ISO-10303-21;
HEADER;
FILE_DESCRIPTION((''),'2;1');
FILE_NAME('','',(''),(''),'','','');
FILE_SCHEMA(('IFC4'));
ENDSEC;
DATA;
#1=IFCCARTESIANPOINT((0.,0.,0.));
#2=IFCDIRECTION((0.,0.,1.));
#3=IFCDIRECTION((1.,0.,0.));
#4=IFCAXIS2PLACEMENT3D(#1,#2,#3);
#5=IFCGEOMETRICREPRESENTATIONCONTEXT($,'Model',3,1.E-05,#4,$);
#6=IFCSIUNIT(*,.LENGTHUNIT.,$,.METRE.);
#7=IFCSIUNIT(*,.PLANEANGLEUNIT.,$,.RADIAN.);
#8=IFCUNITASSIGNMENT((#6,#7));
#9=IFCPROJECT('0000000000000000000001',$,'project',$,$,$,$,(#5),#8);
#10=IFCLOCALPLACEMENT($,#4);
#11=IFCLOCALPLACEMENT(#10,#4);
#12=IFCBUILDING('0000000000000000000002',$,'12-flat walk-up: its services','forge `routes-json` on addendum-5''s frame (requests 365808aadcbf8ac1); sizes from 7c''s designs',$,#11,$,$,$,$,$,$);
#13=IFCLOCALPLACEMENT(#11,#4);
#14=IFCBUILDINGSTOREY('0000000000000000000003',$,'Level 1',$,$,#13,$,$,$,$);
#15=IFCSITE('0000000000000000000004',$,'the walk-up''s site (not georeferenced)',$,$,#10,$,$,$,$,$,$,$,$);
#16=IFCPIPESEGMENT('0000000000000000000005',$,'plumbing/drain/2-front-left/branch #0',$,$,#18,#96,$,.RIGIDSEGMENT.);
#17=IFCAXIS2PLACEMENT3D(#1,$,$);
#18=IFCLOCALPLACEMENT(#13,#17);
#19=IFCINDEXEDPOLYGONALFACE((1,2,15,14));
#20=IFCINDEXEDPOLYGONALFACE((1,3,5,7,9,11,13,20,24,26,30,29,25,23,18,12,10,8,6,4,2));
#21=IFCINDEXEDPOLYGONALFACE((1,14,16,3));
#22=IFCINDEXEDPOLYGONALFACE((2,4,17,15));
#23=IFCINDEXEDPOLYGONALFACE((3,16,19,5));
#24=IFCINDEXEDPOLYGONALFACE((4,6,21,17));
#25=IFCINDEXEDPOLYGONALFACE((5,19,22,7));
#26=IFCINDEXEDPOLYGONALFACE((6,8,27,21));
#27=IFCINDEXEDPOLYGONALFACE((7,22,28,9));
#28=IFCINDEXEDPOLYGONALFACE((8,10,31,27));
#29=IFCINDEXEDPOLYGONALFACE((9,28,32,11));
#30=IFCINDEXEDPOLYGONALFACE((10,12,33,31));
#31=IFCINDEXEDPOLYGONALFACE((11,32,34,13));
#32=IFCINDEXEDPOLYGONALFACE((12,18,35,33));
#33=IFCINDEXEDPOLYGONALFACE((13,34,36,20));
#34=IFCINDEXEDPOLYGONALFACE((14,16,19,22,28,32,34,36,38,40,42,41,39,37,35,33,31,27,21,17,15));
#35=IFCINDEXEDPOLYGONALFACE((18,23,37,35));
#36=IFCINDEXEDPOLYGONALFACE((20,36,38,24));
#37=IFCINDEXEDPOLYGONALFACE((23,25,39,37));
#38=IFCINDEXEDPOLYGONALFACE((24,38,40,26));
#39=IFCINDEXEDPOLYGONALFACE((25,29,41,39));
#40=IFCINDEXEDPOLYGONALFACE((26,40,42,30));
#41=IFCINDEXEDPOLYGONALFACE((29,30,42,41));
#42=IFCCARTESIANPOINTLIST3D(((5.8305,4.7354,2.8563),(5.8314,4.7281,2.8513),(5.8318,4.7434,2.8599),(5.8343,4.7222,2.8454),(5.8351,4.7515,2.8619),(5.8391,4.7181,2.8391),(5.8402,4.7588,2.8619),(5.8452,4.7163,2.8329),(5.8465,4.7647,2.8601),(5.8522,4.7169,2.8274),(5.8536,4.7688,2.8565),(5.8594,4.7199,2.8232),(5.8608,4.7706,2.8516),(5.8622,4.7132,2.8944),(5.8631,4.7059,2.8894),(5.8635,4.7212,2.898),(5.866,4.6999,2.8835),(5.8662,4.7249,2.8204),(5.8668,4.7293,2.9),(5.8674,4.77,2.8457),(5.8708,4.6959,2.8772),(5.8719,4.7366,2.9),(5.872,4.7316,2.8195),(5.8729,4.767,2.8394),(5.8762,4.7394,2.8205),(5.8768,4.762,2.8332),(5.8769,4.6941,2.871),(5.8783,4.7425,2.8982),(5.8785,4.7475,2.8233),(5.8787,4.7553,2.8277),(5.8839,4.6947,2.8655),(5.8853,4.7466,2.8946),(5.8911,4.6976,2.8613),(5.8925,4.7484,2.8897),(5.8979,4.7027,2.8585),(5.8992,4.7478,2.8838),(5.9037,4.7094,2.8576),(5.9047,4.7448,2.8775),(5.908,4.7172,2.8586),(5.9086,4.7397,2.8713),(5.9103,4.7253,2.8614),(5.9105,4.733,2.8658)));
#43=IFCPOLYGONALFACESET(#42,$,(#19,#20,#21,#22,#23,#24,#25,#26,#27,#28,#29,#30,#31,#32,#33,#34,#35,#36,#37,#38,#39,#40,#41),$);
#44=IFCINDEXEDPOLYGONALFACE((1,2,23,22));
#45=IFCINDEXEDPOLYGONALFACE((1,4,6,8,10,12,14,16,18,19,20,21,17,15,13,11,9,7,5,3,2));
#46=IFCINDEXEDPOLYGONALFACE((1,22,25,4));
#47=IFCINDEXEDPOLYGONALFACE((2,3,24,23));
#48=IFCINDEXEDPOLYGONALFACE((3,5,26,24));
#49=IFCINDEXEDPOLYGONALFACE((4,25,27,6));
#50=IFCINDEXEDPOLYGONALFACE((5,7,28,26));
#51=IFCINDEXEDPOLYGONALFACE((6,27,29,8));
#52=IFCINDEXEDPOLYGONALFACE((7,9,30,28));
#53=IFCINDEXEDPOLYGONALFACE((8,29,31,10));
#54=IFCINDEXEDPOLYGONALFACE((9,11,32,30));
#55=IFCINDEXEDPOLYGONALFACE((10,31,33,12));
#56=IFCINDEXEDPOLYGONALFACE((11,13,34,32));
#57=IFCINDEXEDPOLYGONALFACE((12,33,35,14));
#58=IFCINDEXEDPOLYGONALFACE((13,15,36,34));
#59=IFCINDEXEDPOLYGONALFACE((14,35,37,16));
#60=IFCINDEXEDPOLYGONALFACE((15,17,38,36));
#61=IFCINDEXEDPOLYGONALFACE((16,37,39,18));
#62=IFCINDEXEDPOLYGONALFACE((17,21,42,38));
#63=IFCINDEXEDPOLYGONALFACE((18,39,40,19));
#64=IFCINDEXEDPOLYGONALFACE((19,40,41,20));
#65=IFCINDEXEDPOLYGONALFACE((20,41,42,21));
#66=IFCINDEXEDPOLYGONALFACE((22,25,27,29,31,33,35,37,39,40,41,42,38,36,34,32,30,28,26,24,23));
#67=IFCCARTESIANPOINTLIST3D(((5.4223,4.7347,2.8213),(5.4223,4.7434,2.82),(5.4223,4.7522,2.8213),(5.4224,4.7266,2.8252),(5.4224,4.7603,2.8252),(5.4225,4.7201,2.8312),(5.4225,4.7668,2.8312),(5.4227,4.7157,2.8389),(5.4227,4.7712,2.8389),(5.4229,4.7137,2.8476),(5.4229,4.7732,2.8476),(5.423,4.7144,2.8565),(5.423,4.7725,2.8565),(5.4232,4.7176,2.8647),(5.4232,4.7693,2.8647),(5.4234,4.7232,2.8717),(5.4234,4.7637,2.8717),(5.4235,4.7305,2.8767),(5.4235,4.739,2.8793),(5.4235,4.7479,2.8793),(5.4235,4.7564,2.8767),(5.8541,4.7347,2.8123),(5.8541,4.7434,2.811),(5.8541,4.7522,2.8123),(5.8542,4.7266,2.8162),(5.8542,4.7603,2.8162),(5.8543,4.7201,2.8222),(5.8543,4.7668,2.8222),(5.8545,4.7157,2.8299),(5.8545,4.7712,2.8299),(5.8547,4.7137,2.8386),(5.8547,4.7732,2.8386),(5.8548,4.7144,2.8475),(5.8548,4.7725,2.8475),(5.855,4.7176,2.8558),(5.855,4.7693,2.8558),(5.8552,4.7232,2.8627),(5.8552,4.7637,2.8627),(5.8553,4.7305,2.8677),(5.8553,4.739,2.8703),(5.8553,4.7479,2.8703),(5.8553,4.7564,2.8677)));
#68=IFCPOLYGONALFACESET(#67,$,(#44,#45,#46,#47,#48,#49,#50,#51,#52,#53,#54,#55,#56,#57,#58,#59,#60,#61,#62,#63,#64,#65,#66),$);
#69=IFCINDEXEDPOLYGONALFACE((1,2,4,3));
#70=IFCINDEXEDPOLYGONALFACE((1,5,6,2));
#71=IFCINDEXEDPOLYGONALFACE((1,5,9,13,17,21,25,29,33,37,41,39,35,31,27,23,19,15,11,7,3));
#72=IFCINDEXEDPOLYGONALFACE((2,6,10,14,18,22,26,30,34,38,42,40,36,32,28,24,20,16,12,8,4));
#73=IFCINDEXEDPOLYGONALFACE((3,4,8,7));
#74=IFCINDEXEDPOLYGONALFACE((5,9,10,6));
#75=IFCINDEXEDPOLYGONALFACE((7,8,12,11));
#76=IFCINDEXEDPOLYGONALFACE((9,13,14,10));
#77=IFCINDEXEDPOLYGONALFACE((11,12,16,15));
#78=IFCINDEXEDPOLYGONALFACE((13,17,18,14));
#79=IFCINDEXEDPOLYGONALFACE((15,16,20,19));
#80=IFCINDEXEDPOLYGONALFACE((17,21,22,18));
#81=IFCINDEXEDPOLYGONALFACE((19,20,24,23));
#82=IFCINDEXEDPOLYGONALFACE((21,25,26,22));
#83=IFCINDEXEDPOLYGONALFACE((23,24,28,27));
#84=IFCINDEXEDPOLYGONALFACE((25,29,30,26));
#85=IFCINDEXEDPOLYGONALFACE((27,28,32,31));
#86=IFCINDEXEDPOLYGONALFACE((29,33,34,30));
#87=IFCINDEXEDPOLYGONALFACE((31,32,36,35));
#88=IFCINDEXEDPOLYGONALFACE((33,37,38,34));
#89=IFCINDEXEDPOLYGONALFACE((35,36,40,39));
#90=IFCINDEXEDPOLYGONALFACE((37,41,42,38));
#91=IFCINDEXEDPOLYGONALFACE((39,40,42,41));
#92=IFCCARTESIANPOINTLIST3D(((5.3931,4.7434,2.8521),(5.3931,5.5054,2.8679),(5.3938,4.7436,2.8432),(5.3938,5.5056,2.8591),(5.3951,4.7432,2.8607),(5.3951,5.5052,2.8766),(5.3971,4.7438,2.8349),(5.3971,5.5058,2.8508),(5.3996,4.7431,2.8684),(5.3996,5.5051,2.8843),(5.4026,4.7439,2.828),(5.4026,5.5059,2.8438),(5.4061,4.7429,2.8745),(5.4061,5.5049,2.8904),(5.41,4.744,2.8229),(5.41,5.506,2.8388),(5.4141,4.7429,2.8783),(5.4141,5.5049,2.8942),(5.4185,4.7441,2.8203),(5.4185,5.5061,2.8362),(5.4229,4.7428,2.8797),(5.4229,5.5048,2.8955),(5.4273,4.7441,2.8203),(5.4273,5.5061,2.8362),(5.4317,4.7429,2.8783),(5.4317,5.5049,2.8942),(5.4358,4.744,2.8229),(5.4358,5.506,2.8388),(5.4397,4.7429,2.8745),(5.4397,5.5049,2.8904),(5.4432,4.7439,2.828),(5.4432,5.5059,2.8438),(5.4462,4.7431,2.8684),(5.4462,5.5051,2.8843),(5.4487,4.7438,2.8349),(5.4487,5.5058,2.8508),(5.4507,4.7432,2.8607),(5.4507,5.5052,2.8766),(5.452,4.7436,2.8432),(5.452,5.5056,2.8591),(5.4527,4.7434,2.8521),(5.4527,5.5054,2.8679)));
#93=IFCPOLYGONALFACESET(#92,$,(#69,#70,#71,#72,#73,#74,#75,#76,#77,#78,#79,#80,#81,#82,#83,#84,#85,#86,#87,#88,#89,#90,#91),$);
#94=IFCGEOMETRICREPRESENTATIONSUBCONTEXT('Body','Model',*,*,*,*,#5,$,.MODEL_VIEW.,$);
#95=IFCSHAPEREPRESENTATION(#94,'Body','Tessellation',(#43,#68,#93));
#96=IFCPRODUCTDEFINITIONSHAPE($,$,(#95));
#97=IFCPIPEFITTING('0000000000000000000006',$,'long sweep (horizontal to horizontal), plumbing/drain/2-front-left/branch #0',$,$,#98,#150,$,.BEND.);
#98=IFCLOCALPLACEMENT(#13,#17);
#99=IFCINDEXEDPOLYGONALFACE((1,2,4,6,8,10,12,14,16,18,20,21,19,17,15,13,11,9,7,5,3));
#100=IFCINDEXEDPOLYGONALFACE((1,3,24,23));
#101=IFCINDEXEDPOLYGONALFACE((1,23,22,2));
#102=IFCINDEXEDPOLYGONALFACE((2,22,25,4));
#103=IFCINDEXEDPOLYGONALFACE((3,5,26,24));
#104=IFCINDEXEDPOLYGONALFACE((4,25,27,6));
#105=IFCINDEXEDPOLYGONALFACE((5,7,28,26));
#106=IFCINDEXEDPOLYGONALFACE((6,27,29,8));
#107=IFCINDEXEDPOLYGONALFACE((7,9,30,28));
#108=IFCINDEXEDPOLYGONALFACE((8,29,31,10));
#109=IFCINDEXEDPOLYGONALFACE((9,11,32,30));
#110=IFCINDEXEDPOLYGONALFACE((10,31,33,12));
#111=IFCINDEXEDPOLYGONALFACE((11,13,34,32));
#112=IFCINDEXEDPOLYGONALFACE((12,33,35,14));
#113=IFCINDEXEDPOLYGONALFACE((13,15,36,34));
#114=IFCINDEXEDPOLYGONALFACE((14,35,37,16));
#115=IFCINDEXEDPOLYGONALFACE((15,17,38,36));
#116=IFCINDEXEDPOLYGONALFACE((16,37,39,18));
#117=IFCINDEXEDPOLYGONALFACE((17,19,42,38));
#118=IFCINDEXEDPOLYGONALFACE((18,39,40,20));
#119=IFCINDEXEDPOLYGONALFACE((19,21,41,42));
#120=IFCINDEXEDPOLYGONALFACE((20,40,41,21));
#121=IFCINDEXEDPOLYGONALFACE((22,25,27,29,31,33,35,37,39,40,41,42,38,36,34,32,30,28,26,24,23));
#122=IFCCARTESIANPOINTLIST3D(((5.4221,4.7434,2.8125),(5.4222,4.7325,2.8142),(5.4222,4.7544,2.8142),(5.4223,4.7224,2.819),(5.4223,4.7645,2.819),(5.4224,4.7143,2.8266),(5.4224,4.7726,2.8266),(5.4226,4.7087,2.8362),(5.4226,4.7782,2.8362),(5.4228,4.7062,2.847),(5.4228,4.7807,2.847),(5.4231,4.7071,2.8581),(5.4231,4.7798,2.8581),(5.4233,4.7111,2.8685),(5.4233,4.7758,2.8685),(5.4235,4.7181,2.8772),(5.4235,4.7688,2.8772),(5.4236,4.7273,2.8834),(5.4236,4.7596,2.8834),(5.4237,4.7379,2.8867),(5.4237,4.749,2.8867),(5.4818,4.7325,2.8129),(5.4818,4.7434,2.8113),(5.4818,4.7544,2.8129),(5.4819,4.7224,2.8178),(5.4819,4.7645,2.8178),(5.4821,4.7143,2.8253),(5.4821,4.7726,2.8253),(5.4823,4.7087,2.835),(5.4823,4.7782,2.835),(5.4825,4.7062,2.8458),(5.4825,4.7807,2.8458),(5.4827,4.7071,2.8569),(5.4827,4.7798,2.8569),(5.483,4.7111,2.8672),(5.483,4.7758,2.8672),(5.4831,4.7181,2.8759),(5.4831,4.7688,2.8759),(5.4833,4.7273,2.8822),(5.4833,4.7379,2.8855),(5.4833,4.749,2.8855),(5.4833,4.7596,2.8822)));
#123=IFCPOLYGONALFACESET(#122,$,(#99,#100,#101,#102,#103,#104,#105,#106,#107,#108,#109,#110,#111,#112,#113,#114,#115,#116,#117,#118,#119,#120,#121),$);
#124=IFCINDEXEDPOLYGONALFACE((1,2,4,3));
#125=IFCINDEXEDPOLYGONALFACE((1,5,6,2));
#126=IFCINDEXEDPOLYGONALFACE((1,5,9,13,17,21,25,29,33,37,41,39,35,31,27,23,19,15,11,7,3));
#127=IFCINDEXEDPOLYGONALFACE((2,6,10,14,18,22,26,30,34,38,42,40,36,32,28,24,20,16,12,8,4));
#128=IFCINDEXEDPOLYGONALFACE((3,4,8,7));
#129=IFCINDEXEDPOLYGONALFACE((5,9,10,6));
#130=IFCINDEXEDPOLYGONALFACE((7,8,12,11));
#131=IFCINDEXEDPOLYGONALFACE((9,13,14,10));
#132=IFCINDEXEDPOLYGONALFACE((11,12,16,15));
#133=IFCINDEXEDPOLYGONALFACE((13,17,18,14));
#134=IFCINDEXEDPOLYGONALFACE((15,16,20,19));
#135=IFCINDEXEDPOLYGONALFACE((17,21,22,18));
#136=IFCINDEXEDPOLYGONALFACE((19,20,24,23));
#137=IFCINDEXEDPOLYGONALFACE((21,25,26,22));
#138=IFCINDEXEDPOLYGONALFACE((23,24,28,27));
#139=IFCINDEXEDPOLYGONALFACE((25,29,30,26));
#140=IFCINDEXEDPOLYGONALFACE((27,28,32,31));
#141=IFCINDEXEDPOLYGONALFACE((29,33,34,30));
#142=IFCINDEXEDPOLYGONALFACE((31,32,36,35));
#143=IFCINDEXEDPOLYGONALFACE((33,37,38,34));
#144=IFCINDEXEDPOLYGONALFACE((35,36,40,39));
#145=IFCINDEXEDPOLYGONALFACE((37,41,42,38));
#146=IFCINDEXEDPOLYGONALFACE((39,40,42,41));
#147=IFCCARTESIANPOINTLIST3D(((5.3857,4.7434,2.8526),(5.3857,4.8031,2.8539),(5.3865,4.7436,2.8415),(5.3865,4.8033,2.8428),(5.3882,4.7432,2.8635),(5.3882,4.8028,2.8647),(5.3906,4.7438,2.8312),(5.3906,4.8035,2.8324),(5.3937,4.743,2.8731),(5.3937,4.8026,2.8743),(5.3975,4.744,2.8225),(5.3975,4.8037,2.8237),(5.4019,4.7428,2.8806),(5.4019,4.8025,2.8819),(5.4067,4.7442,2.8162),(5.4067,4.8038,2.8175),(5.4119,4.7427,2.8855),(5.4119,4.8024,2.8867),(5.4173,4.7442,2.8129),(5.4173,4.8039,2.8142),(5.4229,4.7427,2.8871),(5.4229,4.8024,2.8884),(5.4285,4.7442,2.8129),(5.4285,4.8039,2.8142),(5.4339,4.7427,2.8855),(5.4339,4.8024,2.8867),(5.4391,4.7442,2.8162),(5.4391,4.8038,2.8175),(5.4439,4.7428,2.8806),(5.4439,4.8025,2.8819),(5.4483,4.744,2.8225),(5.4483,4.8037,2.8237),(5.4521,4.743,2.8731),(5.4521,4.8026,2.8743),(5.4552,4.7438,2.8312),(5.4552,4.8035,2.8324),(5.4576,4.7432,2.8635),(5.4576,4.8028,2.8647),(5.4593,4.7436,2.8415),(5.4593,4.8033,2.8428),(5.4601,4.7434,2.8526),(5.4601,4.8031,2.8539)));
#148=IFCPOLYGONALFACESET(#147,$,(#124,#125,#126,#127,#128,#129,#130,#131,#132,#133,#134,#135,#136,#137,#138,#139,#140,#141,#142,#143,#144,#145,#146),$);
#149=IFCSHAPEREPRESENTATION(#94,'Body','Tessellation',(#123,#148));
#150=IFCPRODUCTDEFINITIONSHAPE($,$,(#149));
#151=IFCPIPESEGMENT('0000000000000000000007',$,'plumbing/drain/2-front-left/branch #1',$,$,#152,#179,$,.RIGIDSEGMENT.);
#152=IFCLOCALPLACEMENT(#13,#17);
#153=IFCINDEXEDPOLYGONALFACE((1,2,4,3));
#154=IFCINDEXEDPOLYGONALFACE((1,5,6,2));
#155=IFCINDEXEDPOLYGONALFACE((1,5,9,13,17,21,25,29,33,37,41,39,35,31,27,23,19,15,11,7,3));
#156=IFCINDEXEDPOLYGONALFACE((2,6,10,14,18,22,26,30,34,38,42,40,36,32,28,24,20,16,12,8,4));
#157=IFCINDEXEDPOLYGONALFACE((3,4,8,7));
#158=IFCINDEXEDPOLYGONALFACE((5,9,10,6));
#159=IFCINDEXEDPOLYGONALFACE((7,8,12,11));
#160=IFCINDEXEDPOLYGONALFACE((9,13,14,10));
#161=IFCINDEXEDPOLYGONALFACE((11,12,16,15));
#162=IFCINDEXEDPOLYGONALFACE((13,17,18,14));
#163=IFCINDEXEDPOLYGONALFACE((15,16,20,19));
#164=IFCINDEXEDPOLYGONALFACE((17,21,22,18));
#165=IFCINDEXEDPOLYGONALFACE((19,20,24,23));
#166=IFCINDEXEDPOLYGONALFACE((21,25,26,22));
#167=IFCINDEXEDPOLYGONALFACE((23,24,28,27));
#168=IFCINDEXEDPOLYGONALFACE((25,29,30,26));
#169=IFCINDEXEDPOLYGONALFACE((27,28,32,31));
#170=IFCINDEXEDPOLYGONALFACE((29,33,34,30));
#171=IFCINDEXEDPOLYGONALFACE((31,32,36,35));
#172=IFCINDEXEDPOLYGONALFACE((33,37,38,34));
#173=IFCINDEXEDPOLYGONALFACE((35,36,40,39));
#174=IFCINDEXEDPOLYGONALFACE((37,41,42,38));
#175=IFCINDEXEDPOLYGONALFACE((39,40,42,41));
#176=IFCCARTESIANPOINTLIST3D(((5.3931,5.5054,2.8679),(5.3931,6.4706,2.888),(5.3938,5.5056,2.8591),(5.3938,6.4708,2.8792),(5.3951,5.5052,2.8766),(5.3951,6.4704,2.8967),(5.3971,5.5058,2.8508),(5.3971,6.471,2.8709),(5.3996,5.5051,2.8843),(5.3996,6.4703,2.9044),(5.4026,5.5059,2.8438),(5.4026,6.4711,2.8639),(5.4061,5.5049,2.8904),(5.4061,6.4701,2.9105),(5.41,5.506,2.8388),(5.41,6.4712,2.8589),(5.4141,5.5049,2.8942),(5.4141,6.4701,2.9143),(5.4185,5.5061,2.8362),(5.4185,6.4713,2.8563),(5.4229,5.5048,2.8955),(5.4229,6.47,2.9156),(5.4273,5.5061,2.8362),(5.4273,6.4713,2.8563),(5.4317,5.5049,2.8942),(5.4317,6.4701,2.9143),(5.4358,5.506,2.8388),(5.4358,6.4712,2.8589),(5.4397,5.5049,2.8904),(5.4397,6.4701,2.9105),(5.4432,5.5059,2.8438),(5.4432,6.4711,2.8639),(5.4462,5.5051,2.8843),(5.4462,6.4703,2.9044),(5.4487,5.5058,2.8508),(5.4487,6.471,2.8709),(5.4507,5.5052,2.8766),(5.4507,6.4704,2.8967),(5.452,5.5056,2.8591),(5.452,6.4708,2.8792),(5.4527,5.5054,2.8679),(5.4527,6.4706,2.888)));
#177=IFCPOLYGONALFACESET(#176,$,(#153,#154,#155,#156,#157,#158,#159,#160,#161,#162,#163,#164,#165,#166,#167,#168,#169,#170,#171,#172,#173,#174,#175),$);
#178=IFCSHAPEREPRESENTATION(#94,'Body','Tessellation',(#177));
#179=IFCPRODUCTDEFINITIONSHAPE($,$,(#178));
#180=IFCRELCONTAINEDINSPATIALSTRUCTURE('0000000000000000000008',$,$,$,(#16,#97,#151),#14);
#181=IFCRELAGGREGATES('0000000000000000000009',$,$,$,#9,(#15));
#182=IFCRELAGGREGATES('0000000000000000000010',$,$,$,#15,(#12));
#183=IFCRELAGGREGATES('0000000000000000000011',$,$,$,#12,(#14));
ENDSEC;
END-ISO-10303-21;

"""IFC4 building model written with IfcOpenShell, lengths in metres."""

from ifc_helpers import new_model, entity, si_unit, frame, origin_with_axes, place, context, subcontext, project, spatial, element, save


model = new_model("IFC4")

# Units and contexts
model_context = context("Model", 3, precision=1e-05, world=origin_with_axes())
body_context = subcontext(model_context, "Body", "Model", "MODEL_VIEW")
ifc_project = project(units=[si_unit("LENGTHUNIT", "METRE"), si_unit("PLANEANGLEUNIT", "RADIAN")], contexts=[model_context])

# Site, building, storey
site_placement = place(None, origin_with_axes())
site = spatial("IfcSite", under=ifc_project, at=site_placement, Name="the walk-up's site (not georeferenced)")
building_placement = place(site_placement, origin_with_axes())
building = spatial("IfcBuilding", under=site, at=building_placement, Name="12-flat walk-up: its services", Description="forge `routes-json` on addendum-5's frame (requests 365808aadcbf8ac1); sizes from 7c's designs")
storey_placement = place(building_placement, origin_with_axes())
storey = spatial("IfcBuildingStorey", under=building, at=storey_placement, Name="Level 1")

# Pipe segment
pipe_segment_1_placement = place(storey_placement, frame((5.8864, 4.7212, 2.8789), z_axis=(0.0, 0.0, 1.0), x_axis=(1.0, 0.0, 0.0)))
element("IfcPipeSegment", 1, at=pipe_segment_1_placement, inside=storey, Name="plumbing/drain/2-front-left/branch #0", PredefinedType="RIGIDSEGMENT", context=body_context, shape_type="AdvancedSweptSolid", body=[
    entity("IfcSweptDiskSolid", entity("IfcPolyline", [entity("IfcCartesianPoint", [0.0, 0.0, 0.0]), entity("IfcCartesianPoint", [-0.0318, 0.0222, -0.0381])]), 0.0298),
    entity("IfcSweptDiskSolid", entity("IfcPolyline", [entity("IfcCartesianPoint", [-0.0318, 0.0222, -0.0381]), entity("IfcCartesianPoint", [-0.4635, 0.0222, -0.0291])]), 0.0298),
    entity("IfcSweptDiskSolid", entity("IfcPolyline", [entity("IfcCartesianPoint", [-0.4635, 0.0222, -0.0291]), entity("IfcCartesianPoint", [-0.4635, 0.7842, -0.0132])]), 0.0298),
])

# Pipe fitting
pipe_fitting_1_placement = place(storey_placement, frame((5.4826, 4.7434, 2.8486), z_axis=(0.0, 0.0, 1.0), x_axis=(1.0, 0.0, 0.0)))
element("IfcPipeFitting", 2, at=pipe_fitting_1_placement, inside=storey, Name="long sweep (horizontal to horizontal), plumbing/drain/2-front-left/branch #0", PredefinedType="BEND", context=body_context, shape_type="AdvancedSweptSolid", body=[
    entity("IfcSweptDiskSolid", entity("IfcPolyline", [entity("IfcCartesianPoint", [0.0, 0.0, 0.0]), entity("IfcCartesianPoint", [-0.0597, 0.0, 0.0012])]), 0.0373),
    entity("IfcSweptDiskSolid", entity("IfcPolyline", [entity("IfcCartesianPoint", [-0.0597, 0.0, 0.0012]), entity("IfcCartesianPoint", [-0.0597, 0.0597, 0.0025])]), 0.0373),
])

# Pipe segment
pipe_segment_2_placement = place(storey_placement, frame((5.4229, 5.5054, 2.8657), z_axis=(0.0, 0.0, 1.0), x_axis=(1.0, 0.0, 0.0)))
element("IfcPipeSegment", 3, at=pipe_segment_2_placement, inside=storey, Name="plumbing/drain/2-front-left/branch #1", PredefinedType="RIGIDSEGMENT", context=body_context, shape_type="AdvancedSweptSolid", body=[
    entity("IfcSweptDiskSolid", entity("IfcPolyline", [entity("IfcCartesianPoint", [0.0, 0.0, 0.0]), entity("IfcCartesianPoint", [0.0, 0.9652, 0.0201])]), 0.0298),
])

save(model, "model.ifc")
